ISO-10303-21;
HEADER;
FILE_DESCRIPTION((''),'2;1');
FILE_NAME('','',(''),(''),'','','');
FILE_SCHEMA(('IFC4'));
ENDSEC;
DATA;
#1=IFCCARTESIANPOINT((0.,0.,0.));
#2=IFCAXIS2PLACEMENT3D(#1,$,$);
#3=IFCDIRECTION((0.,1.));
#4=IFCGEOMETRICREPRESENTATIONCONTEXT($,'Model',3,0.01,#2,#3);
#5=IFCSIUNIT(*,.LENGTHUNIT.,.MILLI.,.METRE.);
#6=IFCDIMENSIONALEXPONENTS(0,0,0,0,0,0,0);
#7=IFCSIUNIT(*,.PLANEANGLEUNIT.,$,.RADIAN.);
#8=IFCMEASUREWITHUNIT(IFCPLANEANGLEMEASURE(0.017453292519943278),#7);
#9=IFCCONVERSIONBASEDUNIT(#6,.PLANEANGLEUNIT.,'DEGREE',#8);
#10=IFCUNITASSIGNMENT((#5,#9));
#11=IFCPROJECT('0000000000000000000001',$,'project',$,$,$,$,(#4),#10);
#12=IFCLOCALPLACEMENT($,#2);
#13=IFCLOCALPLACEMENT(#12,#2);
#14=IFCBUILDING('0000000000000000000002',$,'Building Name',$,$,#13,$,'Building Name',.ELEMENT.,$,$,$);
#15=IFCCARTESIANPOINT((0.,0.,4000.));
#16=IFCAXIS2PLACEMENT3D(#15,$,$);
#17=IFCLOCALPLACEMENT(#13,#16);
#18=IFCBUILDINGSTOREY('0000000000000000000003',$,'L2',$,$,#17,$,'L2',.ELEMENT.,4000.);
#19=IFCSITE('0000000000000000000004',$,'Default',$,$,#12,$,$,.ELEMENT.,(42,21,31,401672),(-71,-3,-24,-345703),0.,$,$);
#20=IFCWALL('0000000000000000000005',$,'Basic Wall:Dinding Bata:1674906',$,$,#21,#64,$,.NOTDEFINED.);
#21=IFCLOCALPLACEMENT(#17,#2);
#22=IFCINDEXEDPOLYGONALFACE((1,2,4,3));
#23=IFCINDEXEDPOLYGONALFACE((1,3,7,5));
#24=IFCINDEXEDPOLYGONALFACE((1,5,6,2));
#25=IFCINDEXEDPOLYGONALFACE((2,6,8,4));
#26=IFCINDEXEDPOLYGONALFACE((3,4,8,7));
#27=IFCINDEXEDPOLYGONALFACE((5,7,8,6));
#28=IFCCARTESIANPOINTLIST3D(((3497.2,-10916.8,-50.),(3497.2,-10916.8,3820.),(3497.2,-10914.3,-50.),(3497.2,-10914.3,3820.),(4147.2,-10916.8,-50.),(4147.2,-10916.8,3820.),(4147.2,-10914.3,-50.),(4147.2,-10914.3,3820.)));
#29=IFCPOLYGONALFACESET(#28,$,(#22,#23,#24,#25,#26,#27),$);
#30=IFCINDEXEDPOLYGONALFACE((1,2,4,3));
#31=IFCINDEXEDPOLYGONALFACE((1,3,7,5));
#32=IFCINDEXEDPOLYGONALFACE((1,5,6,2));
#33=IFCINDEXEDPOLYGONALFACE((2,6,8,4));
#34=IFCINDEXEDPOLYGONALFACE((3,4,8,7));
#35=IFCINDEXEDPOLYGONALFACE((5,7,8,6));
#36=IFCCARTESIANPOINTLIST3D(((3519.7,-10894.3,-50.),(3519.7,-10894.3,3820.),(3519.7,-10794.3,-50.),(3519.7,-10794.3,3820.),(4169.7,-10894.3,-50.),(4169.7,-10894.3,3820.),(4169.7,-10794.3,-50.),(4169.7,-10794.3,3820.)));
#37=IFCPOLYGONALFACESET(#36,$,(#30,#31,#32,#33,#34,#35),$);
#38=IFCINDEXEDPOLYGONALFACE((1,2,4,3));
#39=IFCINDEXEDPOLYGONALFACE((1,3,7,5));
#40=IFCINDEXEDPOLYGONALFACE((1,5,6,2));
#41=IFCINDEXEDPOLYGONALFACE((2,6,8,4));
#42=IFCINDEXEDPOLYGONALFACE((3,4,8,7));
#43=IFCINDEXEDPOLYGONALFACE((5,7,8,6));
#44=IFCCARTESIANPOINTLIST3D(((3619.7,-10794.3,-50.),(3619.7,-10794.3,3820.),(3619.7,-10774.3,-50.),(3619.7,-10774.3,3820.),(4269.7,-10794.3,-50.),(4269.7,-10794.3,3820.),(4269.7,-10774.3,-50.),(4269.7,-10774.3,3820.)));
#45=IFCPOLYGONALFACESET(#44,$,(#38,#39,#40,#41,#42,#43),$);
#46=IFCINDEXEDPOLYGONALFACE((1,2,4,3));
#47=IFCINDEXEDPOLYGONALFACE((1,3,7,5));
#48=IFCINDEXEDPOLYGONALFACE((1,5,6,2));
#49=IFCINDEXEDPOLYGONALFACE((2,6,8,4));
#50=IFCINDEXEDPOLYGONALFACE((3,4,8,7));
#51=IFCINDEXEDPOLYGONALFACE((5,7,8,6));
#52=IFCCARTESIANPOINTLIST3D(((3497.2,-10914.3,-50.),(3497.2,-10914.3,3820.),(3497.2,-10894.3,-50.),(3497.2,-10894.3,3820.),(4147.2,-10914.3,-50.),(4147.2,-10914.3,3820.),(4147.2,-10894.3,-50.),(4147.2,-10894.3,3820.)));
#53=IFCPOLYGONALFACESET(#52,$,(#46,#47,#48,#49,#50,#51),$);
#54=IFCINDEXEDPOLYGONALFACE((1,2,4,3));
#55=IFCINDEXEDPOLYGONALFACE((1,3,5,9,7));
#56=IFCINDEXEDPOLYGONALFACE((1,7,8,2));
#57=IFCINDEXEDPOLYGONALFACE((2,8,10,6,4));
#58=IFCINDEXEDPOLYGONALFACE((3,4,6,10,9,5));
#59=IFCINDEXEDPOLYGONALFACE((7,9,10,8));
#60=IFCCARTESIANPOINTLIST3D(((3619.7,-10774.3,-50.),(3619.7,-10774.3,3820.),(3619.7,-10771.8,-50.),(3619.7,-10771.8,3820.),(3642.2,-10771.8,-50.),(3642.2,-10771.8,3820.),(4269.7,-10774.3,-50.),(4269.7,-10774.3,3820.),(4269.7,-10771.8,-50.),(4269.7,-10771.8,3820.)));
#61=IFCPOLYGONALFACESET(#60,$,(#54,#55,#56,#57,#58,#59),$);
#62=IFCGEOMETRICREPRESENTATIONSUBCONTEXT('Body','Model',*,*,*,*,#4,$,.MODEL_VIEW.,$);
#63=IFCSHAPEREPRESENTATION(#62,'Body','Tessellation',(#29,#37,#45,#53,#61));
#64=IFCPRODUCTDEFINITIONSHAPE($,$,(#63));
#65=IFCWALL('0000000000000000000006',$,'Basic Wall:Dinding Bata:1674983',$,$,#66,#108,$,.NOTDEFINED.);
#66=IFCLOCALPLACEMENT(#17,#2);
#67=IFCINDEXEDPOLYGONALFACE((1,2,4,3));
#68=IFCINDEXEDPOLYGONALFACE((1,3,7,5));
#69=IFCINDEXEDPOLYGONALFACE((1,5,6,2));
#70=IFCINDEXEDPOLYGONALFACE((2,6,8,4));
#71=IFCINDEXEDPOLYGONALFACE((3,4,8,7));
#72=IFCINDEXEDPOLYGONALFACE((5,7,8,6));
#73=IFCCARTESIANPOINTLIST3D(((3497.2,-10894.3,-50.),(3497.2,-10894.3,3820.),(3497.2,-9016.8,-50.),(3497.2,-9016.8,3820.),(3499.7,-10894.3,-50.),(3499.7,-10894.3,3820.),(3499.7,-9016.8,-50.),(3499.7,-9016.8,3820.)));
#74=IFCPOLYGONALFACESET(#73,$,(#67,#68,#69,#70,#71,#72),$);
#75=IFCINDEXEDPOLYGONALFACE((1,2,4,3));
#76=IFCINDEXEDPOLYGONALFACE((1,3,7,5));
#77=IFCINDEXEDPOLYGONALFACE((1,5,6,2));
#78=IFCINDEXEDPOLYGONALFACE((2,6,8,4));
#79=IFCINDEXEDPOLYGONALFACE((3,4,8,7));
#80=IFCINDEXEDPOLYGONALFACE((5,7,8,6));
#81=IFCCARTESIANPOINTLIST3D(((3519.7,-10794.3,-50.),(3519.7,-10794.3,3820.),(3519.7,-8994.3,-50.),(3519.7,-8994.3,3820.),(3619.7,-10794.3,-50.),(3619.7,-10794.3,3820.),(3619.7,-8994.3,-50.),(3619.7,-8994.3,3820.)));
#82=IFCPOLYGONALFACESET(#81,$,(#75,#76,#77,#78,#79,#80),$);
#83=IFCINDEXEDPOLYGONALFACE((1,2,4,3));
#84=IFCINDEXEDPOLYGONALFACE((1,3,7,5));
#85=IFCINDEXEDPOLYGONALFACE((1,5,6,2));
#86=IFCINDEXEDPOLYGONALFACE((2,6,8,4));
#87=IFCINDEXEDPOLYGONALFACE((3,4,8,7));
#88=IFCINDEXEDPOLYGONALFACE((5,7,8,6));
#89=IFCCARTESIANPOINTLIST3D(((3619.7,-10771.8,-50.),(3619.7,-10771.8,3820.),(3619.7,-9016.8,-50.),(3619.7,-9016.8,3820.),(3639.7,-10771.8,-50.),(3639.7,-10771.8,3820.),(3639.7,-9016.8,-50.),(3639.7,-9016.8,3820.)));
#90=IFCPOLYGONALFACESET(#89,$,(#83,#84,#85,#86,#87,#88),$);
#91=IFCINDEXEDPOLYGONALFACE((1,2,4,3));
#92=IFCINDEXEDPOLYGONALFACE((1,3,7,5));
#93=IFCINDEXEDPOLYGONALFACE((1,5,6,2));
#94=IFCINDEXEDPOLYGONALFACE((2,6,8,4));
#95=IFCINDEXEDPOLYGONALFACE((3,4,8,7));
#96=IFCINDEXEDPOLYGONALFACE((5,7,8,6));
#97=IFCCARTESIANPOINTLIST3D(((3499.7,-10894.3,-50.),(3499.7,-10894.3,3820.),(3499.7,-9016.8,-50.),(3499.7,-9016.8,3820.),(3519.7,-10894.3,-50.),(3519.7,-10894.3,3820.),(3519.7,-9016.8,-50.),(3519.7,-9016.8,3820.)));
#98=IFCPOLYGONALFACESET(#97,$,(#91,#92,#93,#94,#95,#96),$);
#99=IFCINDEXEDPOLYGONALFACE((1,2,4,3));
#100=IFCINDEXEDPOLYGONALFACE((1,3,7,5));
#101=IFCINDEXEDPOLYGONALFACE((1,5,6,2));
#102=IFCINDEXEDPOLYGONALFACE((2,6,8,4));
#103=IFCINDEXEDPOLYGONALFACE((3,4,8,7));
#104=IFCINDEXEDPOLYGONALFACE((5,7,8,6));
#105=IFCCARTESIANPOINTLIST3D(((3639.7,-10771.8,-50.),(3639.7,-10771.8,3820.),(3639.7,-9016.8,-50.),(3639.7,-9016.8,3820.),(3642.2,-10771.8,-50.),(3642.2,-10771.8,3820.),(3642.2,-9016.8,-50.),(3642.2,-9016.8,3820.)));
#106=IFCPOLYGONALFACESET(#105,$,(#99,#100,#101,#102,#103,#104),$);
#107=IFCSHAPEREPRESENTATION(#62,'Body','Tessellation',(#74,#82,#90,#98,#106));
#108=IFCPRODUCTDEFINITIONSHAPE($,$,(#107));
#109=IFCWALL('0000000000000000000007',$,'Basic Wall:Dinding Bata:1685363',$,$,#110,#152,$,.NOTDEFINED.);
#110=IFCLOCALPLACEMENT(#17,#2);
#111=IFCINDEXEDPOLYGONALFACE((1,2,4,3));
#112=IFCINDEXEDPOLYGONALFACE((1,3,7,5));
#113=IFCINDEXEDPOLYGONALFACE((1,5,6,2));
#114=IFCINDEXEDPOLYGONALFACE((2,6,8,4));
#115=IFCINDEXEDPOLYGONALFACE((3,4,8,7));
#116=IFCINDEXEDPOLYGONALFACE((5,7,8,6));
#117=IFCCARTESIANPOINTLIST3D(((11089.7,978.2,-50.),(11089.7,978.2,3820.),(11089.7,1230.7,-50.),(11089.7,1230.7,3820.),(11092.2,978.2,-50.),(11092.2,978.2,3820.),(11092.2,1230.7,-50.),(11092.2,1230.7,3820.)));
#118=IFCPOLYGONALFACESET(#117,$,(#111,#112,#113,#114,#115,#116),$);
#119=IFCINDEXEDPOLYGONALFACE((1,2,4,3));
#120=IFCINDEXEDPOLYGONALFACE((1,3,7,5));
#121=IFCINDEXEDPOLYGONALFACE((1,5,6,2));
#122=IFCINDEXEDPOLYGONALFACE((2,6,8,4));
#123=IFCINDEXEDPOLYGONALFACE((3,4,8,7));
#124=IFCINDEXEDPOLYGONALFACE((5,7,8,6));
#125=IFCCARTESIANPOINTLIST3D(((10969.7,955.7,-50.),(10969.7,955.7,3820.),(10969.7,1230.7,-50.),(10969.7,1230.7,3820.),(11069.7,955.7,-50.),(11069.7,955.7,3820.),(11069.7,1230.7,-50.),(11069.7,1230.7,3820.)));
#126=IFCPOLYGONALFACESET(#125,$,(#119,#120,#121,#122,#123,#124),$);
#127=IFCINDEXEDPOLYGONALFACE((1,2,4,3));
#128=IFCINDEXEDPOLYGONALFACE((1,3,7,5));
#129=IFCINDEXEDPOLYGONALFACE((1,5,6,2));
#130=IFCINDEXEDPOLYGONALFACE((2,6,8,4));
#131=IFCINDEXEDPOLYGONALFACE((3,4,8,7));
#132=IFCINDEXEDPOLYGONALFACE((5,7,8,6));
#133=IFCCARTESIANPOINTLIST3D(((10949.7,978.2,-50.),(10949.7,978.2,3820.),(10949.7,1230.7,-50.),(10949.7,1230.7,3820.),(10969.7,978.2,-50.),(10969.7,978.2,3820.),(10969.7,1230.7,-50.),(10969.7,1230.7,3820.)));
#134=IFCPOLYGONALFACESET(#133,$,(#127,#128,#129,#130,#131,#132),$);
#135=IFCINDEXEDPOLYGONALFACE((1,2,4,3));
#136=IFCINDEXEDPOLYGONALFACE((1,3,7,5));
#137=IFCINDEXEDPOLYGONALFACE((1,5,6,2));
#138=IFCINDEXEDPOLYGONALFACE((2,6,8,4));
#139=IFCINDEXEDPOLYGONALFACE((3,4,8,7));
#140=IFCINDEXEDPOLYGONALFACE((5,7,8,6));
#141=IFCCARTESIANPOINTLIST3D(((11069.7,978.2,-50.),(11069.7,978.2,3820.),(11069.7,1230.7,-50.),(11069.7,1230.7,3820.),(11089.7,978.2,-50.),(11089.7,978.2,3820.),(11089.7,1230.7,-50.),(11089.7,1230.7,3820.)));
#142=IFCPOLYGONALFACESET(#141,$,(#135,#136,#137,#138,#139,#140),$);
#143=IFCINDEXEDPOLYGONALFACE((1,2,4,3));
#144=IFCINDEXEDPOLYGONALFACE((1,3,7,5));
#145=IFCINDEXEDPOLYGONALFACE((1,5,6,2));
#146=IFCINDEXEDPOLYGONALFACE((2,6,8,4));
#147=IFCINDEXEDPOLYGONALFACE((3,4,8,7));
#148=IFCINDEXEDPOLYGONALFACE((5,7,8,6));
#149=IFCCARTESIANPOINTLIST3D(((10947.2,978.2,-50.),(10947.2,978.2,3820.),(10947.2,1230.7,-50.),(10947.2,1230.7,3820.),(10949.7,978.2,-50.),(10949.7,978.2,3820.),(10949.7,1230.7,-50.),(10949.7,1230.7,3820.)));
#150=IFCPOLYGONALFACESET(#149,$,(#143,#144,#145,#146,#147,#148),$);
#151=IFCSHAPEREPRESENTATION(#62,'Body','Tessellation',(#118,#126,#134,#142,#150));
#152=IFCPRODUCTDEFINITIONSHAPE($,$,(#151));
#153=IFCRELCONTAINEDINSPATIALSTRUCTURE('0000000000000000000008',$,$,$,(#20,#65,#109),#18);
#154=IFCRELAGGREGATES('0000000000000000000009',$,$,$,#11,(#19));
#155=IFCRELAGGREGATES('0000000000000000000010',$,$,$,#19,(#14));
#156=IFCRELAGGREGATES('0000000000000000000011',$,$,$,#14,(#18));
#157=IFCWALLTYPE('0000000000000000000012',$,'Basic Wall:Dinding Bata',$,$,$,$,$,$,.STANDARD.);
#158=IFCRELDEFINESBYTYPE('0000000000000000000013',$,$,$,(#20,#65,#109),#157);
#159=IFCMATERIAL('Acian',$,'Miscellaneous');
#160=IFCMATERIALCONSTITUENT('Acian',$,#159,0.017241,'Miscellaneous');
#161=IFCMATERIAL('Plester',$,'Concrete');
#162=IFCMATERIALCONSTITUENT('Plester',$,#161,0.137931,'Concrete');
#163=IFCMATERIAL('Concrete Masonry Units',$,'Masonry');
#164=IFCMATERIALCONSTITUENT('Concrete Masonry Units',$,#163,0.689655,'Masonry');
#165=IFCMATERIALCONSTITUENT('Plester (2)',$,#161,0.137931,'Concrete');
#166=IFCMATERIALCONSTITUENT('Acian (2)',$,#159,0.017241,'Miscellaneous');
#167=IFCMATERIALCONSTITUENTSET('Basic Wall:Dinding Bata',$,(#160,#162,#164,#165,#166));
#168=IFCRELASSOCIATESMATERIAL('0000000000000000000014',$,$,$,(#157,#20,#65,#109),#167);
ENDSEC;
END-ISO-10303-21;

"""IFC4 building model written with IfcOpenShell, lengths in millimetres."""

from ifc_helpers import new_model, entity, si_unit, converted_unit, direction, frame, origin, place, context, subcontext, project, spatial, indexed_curve, outline, extrude, material, constituent, constituent_set, type_object, element, save


model = new_model("IFC4")

# Units and contexts
model_context = context("Model", 3, precision=0.01, world=origin(), true_north=direction((0.0, 1.0)))
body_context = subcontext(model_context, "Body", "Model", "MODEL_VIEW")
ifc_project = project(units=[si_unit("LENGTHUNIT", "METRE", prefix="MILLI"), converted_unit("PLANEANGLEUNIT", "DEGREE", entity("IfcPlaneAngleMeasure", 0.017453292519943278), si_unit("PLANEANGLEUNIT", "RADIAN"), dimensions=[0, 0, 0, 0, 0, 0, 0])], contexts=[model_context])

# Site, building, storey
site_placement = place(None, origin())
site = spatial("IfcSite", under=ifc_project, at=site_placement, Name="Default", CompositionType="ELEMENT", RefLatitude=(42, 21, 31, 401672), RefLongitude=(-71, -3, -24, -345703), RefElevation=0.0)
building_placement = place(site_placement, origin())
building = spatial("IfcBuilding", under=site, at=building_placement, Name="Building Name", LongName="Building Name", CompositionType="ELEMENT")
storey_placement = place(building_placement, frame((0.0, 0.0, 4000.0)))
storey = spatial("IfcBuildingStorey", under=building, at=storey_placement, Name="L2", LongName="L2", CompositionType="ELEMENT", Elevation=4000.0)

# Walls
ifc_material_1 = material(Name="Acian", Category="Miscellaneous")
ifc_constituent_1 = constituent(ifc_material_1, Name="Acian", Category="Miscellaneous", fraction=0.017241)
ifc_material_2 = material(Name="Plester", Category="Concrete")
ifc_constituent_2 = constituent(ifc_material_2, Name="Plester", Category="Concrete", fraction=0.137931)
ifc_material_3 = material(Name="Concrete Masonry Units", Category="Masonry")
ifc_constituent_3 = constituent(ifc_material_3, Name="Concrete Masonry Units", Category="Masonry", fraction=0.689655)
ifc_constituent_4 = constituent(ifc_material_2, Name="Plester (2)", Category="Concrete", fraction=0.137931)
ifc_constituent_5 = constituent(ifc_material_1, Name="Acian (2)", Category="Miscellaneous", fraction=0.017241)
ifc_constituent_set = constituent_set(constituents=[ifc_constituent_1, ifc_constituent_2, ifc_constituent_3, ifc_constituent_4, ifc_constituent_5], Name="Basic Wall:Dinding Bata")
wall_type = type_object("IfcWallType", Name="Basic Wall:Dinding Bata", PredefinedType="STANDARD", material=ifc_constituent_set)
wall_1_placement = place(storey_placement, frame((4147.2, -10844.3, -50.0), z_axis=(0.0, 0.0, 1.0), x_axis=(-1.0, 0.0, 0.0)))
element("IfcWall", 1, at=wall_1_placement, inside=storey, type_object=wall_type, material=ifc_constituent_set, Name="Basic Wall:Dinding Bata:1674906", PredefinedType="NOTDEFINED", context=body_context, shape_type="SweptSolid", body=[
    extrude(outline(indexed_curve([(-1.3, -325.0), (1.2, -325.0), (1.3, 325.0), (-1.2, 325.0), (-1.3, -325.0)], self_intersect=False)), frame((325.0, 71.2, 0.0), z_axis=(0.0, 0.0, 1.0), x_axis=(0.0, -1.0, 0.0)), (0.0, 0.0, 1.0), 3870.0),
    extrude(outline(indexed_curve([(-325.0, -50.0), (325.0, -50.0), (325.0, 50.0), (-325.0, 50.0), (-325.0, -50.0)], self_intersect=False)), frame((302.5, 0.0, 0.0)), (0.0, 0.0, 1.0), 3870.0),
    extrude(outline(indexed_curve([(-325.0, -10.0), (325.0, -10.0), (325.0, 10.0), (-325.0, 10.0), (-325.0, -10.0)], self_intersect=False)), frame((202.5, -60.0, 0.0)), (0.0, 0.0, 1.0), 3870.0),
    extrude(outline(indexed_curve([(-325.0, -10.0), (325.0, -10.0), (325.0, 10.0), (-325.0, 10.0), (-325.0, -10.0)], self_intersect=False)), frame((325.0, 60.0, 0.0)), (0.0, 0.0, 1.0), 3870.0),
    extrude(outline(indexed_curve([(242.0, -1.0), (264.5, -1.0), (264.5, 1.5), (-385.5, 1.5), (-385.5, -1.0), (242.0, -1.0)], self_intersect=False)), frame((263.0, -71.5, 0.0)), (0.0, 0.0, 1.0), 3870.0),
])
wall_2_placement = place(storey_placement, frame((3569.7, -10771.8, -50.0), z_axis=(0.0, 0.0, 1.0), x_axis=(0.0, 1.0, 0.0)))
element("IfcWall", 2, at=wall_2_placement, inside=storey, type_object=wall_type, material=ifc_constituent_set, Name="Basic Wall:Dinding Bata:1674983", PredefinedType="NOTDEFINED", context=body_context, shape_type="SweptSolid", body=[
    extrude(outline(indexed_curve([(-1.3, -938.8), (1.2, -938.8), (1.3, 938.8), (-1.2, 938.8), (-1.3, -938.8)], self_intersect=False)), frame((816.3, 71.2, 0.0), z_axis=(0.0, 0.0, 1.0), x_axis=(0.0, -1.0, 0.0)), (0.0, 0.0, 1.0), 3870.0),
    extrude(outline(indexed_curve([(-900.0, -50.0), (900.0, -50.0), (900.0, 50.0), (-900.0, 50.0), (-900.0, -50.0)], self_intersect=False)), frame((877.5, 0.0, 0.0)), (0.0, 0.0, 1.0), 3870.0),
    extrude(outline(indexed_curve([(-877.5, -10.0), (877.5, -10.0), (877.5, 10.0), (-877.5, 10.0), (-877.5, -10.0)], self_intersect=False)), frame((877.5, -60.0, 0.0)), (0.0, 0.0, 1.0), 3870.0),
    extrude(outline(indexed_curve([(-938.8, -10.0), (938.8, -10.0), (938.8, 10.0), (-938.8, 10.0), (-938.8, -10.0)], self_intersect=False)), frame((816.3, 60.0, 0.0)), (0.0, 0.0, 1.0), 3870.0),
    extrude(outline(indexed_curve([(-1.3, -877.5), (1.2, -877.5), (1.3, 877.5), (-1.2, 877.5), (-1.3, -877.5)], self_intersect=False)), frame((877.5, -71.3, 0.0), z_axis=(0.0, 0.0, 1.0), x_axis=(0.0, 1.0, 0.0)), (0.0, 0.0, 1.0), 3870.0),
])
wall_3_placement = place(storey_placement, frame((11019.7, 1230.7, -50.0), z_axis=(0.0, 0.0, 1.0), x_axis=(0.0, -1.0, 0.0)))
element("IfcWall", 3, at=wall_3_placement, inside=storey, type_object=wall_type, material=ifc_constituent_set, Name="Basic Wall:Dinding Bata:1685363", PredefinedType="NOTDEFINED", context=body_context, shape_type="SweptSolid", body=[
    extrude(outline(indexed_curve([(-1.3, -126.3), (1.2, -126.3), (1.2, 126.3), (-1.3, 126.3), (-1.3, -126.3)], self_intersect=False)), frame((126.3, 71.2, 0.0), z_axis=(0.0, 0.0, 1.0), x_axis=(0.0, -1.0, 0.0)), (0.0, 0.0, 1.0), 3870.0),
    extrude(outline(indexed_curve([(-137.5, -50.0), (137.5, -50.0), (137.5, 50.0), (-137.5, 50.0), (-137.5, -50.0)], self_intersect=False)), frame((137.5, 0.0, 0.0)), (0.0, 0.0, 1.0), 3870.0),
    extrude(outline(indexed_curve([(-126.3, -10.0), (126.3, -10.0), (126.3, 10.0), (-126.3, 10.0), (-126.3, -10.0)], self_intersect=False)), frame((126.3, -60.0, 0.0)), (0.0, 0.0, 1.0), 3870.0),
    extrude(outline(indexed_curve([(-126.3, -10.0), (126.3, -10.0), (126.3, 10.0), (-126.3, 10.0), (-126.3, -10.0)], self_intersect=False)), frame((126.3, 60.0, 0.0)), (0.0, 0.0, 1.0), 3870.0),
    extrude(outline(indexed_curve([(-1.2, -126.3), (1.2, -126.3), (1.2, 126.3), (-1.2, 126.3), (-1.2, -126.3)], self_intersect=False)), frame((126.3, -71.2, 0.0), z_axis=(0.0, 0.0, 1.0), x_axis=(0.0, 1.0, 0.0)), (0.0, 0.0, 1.0), 3870.0),
])

save(model, "model.ifc")
